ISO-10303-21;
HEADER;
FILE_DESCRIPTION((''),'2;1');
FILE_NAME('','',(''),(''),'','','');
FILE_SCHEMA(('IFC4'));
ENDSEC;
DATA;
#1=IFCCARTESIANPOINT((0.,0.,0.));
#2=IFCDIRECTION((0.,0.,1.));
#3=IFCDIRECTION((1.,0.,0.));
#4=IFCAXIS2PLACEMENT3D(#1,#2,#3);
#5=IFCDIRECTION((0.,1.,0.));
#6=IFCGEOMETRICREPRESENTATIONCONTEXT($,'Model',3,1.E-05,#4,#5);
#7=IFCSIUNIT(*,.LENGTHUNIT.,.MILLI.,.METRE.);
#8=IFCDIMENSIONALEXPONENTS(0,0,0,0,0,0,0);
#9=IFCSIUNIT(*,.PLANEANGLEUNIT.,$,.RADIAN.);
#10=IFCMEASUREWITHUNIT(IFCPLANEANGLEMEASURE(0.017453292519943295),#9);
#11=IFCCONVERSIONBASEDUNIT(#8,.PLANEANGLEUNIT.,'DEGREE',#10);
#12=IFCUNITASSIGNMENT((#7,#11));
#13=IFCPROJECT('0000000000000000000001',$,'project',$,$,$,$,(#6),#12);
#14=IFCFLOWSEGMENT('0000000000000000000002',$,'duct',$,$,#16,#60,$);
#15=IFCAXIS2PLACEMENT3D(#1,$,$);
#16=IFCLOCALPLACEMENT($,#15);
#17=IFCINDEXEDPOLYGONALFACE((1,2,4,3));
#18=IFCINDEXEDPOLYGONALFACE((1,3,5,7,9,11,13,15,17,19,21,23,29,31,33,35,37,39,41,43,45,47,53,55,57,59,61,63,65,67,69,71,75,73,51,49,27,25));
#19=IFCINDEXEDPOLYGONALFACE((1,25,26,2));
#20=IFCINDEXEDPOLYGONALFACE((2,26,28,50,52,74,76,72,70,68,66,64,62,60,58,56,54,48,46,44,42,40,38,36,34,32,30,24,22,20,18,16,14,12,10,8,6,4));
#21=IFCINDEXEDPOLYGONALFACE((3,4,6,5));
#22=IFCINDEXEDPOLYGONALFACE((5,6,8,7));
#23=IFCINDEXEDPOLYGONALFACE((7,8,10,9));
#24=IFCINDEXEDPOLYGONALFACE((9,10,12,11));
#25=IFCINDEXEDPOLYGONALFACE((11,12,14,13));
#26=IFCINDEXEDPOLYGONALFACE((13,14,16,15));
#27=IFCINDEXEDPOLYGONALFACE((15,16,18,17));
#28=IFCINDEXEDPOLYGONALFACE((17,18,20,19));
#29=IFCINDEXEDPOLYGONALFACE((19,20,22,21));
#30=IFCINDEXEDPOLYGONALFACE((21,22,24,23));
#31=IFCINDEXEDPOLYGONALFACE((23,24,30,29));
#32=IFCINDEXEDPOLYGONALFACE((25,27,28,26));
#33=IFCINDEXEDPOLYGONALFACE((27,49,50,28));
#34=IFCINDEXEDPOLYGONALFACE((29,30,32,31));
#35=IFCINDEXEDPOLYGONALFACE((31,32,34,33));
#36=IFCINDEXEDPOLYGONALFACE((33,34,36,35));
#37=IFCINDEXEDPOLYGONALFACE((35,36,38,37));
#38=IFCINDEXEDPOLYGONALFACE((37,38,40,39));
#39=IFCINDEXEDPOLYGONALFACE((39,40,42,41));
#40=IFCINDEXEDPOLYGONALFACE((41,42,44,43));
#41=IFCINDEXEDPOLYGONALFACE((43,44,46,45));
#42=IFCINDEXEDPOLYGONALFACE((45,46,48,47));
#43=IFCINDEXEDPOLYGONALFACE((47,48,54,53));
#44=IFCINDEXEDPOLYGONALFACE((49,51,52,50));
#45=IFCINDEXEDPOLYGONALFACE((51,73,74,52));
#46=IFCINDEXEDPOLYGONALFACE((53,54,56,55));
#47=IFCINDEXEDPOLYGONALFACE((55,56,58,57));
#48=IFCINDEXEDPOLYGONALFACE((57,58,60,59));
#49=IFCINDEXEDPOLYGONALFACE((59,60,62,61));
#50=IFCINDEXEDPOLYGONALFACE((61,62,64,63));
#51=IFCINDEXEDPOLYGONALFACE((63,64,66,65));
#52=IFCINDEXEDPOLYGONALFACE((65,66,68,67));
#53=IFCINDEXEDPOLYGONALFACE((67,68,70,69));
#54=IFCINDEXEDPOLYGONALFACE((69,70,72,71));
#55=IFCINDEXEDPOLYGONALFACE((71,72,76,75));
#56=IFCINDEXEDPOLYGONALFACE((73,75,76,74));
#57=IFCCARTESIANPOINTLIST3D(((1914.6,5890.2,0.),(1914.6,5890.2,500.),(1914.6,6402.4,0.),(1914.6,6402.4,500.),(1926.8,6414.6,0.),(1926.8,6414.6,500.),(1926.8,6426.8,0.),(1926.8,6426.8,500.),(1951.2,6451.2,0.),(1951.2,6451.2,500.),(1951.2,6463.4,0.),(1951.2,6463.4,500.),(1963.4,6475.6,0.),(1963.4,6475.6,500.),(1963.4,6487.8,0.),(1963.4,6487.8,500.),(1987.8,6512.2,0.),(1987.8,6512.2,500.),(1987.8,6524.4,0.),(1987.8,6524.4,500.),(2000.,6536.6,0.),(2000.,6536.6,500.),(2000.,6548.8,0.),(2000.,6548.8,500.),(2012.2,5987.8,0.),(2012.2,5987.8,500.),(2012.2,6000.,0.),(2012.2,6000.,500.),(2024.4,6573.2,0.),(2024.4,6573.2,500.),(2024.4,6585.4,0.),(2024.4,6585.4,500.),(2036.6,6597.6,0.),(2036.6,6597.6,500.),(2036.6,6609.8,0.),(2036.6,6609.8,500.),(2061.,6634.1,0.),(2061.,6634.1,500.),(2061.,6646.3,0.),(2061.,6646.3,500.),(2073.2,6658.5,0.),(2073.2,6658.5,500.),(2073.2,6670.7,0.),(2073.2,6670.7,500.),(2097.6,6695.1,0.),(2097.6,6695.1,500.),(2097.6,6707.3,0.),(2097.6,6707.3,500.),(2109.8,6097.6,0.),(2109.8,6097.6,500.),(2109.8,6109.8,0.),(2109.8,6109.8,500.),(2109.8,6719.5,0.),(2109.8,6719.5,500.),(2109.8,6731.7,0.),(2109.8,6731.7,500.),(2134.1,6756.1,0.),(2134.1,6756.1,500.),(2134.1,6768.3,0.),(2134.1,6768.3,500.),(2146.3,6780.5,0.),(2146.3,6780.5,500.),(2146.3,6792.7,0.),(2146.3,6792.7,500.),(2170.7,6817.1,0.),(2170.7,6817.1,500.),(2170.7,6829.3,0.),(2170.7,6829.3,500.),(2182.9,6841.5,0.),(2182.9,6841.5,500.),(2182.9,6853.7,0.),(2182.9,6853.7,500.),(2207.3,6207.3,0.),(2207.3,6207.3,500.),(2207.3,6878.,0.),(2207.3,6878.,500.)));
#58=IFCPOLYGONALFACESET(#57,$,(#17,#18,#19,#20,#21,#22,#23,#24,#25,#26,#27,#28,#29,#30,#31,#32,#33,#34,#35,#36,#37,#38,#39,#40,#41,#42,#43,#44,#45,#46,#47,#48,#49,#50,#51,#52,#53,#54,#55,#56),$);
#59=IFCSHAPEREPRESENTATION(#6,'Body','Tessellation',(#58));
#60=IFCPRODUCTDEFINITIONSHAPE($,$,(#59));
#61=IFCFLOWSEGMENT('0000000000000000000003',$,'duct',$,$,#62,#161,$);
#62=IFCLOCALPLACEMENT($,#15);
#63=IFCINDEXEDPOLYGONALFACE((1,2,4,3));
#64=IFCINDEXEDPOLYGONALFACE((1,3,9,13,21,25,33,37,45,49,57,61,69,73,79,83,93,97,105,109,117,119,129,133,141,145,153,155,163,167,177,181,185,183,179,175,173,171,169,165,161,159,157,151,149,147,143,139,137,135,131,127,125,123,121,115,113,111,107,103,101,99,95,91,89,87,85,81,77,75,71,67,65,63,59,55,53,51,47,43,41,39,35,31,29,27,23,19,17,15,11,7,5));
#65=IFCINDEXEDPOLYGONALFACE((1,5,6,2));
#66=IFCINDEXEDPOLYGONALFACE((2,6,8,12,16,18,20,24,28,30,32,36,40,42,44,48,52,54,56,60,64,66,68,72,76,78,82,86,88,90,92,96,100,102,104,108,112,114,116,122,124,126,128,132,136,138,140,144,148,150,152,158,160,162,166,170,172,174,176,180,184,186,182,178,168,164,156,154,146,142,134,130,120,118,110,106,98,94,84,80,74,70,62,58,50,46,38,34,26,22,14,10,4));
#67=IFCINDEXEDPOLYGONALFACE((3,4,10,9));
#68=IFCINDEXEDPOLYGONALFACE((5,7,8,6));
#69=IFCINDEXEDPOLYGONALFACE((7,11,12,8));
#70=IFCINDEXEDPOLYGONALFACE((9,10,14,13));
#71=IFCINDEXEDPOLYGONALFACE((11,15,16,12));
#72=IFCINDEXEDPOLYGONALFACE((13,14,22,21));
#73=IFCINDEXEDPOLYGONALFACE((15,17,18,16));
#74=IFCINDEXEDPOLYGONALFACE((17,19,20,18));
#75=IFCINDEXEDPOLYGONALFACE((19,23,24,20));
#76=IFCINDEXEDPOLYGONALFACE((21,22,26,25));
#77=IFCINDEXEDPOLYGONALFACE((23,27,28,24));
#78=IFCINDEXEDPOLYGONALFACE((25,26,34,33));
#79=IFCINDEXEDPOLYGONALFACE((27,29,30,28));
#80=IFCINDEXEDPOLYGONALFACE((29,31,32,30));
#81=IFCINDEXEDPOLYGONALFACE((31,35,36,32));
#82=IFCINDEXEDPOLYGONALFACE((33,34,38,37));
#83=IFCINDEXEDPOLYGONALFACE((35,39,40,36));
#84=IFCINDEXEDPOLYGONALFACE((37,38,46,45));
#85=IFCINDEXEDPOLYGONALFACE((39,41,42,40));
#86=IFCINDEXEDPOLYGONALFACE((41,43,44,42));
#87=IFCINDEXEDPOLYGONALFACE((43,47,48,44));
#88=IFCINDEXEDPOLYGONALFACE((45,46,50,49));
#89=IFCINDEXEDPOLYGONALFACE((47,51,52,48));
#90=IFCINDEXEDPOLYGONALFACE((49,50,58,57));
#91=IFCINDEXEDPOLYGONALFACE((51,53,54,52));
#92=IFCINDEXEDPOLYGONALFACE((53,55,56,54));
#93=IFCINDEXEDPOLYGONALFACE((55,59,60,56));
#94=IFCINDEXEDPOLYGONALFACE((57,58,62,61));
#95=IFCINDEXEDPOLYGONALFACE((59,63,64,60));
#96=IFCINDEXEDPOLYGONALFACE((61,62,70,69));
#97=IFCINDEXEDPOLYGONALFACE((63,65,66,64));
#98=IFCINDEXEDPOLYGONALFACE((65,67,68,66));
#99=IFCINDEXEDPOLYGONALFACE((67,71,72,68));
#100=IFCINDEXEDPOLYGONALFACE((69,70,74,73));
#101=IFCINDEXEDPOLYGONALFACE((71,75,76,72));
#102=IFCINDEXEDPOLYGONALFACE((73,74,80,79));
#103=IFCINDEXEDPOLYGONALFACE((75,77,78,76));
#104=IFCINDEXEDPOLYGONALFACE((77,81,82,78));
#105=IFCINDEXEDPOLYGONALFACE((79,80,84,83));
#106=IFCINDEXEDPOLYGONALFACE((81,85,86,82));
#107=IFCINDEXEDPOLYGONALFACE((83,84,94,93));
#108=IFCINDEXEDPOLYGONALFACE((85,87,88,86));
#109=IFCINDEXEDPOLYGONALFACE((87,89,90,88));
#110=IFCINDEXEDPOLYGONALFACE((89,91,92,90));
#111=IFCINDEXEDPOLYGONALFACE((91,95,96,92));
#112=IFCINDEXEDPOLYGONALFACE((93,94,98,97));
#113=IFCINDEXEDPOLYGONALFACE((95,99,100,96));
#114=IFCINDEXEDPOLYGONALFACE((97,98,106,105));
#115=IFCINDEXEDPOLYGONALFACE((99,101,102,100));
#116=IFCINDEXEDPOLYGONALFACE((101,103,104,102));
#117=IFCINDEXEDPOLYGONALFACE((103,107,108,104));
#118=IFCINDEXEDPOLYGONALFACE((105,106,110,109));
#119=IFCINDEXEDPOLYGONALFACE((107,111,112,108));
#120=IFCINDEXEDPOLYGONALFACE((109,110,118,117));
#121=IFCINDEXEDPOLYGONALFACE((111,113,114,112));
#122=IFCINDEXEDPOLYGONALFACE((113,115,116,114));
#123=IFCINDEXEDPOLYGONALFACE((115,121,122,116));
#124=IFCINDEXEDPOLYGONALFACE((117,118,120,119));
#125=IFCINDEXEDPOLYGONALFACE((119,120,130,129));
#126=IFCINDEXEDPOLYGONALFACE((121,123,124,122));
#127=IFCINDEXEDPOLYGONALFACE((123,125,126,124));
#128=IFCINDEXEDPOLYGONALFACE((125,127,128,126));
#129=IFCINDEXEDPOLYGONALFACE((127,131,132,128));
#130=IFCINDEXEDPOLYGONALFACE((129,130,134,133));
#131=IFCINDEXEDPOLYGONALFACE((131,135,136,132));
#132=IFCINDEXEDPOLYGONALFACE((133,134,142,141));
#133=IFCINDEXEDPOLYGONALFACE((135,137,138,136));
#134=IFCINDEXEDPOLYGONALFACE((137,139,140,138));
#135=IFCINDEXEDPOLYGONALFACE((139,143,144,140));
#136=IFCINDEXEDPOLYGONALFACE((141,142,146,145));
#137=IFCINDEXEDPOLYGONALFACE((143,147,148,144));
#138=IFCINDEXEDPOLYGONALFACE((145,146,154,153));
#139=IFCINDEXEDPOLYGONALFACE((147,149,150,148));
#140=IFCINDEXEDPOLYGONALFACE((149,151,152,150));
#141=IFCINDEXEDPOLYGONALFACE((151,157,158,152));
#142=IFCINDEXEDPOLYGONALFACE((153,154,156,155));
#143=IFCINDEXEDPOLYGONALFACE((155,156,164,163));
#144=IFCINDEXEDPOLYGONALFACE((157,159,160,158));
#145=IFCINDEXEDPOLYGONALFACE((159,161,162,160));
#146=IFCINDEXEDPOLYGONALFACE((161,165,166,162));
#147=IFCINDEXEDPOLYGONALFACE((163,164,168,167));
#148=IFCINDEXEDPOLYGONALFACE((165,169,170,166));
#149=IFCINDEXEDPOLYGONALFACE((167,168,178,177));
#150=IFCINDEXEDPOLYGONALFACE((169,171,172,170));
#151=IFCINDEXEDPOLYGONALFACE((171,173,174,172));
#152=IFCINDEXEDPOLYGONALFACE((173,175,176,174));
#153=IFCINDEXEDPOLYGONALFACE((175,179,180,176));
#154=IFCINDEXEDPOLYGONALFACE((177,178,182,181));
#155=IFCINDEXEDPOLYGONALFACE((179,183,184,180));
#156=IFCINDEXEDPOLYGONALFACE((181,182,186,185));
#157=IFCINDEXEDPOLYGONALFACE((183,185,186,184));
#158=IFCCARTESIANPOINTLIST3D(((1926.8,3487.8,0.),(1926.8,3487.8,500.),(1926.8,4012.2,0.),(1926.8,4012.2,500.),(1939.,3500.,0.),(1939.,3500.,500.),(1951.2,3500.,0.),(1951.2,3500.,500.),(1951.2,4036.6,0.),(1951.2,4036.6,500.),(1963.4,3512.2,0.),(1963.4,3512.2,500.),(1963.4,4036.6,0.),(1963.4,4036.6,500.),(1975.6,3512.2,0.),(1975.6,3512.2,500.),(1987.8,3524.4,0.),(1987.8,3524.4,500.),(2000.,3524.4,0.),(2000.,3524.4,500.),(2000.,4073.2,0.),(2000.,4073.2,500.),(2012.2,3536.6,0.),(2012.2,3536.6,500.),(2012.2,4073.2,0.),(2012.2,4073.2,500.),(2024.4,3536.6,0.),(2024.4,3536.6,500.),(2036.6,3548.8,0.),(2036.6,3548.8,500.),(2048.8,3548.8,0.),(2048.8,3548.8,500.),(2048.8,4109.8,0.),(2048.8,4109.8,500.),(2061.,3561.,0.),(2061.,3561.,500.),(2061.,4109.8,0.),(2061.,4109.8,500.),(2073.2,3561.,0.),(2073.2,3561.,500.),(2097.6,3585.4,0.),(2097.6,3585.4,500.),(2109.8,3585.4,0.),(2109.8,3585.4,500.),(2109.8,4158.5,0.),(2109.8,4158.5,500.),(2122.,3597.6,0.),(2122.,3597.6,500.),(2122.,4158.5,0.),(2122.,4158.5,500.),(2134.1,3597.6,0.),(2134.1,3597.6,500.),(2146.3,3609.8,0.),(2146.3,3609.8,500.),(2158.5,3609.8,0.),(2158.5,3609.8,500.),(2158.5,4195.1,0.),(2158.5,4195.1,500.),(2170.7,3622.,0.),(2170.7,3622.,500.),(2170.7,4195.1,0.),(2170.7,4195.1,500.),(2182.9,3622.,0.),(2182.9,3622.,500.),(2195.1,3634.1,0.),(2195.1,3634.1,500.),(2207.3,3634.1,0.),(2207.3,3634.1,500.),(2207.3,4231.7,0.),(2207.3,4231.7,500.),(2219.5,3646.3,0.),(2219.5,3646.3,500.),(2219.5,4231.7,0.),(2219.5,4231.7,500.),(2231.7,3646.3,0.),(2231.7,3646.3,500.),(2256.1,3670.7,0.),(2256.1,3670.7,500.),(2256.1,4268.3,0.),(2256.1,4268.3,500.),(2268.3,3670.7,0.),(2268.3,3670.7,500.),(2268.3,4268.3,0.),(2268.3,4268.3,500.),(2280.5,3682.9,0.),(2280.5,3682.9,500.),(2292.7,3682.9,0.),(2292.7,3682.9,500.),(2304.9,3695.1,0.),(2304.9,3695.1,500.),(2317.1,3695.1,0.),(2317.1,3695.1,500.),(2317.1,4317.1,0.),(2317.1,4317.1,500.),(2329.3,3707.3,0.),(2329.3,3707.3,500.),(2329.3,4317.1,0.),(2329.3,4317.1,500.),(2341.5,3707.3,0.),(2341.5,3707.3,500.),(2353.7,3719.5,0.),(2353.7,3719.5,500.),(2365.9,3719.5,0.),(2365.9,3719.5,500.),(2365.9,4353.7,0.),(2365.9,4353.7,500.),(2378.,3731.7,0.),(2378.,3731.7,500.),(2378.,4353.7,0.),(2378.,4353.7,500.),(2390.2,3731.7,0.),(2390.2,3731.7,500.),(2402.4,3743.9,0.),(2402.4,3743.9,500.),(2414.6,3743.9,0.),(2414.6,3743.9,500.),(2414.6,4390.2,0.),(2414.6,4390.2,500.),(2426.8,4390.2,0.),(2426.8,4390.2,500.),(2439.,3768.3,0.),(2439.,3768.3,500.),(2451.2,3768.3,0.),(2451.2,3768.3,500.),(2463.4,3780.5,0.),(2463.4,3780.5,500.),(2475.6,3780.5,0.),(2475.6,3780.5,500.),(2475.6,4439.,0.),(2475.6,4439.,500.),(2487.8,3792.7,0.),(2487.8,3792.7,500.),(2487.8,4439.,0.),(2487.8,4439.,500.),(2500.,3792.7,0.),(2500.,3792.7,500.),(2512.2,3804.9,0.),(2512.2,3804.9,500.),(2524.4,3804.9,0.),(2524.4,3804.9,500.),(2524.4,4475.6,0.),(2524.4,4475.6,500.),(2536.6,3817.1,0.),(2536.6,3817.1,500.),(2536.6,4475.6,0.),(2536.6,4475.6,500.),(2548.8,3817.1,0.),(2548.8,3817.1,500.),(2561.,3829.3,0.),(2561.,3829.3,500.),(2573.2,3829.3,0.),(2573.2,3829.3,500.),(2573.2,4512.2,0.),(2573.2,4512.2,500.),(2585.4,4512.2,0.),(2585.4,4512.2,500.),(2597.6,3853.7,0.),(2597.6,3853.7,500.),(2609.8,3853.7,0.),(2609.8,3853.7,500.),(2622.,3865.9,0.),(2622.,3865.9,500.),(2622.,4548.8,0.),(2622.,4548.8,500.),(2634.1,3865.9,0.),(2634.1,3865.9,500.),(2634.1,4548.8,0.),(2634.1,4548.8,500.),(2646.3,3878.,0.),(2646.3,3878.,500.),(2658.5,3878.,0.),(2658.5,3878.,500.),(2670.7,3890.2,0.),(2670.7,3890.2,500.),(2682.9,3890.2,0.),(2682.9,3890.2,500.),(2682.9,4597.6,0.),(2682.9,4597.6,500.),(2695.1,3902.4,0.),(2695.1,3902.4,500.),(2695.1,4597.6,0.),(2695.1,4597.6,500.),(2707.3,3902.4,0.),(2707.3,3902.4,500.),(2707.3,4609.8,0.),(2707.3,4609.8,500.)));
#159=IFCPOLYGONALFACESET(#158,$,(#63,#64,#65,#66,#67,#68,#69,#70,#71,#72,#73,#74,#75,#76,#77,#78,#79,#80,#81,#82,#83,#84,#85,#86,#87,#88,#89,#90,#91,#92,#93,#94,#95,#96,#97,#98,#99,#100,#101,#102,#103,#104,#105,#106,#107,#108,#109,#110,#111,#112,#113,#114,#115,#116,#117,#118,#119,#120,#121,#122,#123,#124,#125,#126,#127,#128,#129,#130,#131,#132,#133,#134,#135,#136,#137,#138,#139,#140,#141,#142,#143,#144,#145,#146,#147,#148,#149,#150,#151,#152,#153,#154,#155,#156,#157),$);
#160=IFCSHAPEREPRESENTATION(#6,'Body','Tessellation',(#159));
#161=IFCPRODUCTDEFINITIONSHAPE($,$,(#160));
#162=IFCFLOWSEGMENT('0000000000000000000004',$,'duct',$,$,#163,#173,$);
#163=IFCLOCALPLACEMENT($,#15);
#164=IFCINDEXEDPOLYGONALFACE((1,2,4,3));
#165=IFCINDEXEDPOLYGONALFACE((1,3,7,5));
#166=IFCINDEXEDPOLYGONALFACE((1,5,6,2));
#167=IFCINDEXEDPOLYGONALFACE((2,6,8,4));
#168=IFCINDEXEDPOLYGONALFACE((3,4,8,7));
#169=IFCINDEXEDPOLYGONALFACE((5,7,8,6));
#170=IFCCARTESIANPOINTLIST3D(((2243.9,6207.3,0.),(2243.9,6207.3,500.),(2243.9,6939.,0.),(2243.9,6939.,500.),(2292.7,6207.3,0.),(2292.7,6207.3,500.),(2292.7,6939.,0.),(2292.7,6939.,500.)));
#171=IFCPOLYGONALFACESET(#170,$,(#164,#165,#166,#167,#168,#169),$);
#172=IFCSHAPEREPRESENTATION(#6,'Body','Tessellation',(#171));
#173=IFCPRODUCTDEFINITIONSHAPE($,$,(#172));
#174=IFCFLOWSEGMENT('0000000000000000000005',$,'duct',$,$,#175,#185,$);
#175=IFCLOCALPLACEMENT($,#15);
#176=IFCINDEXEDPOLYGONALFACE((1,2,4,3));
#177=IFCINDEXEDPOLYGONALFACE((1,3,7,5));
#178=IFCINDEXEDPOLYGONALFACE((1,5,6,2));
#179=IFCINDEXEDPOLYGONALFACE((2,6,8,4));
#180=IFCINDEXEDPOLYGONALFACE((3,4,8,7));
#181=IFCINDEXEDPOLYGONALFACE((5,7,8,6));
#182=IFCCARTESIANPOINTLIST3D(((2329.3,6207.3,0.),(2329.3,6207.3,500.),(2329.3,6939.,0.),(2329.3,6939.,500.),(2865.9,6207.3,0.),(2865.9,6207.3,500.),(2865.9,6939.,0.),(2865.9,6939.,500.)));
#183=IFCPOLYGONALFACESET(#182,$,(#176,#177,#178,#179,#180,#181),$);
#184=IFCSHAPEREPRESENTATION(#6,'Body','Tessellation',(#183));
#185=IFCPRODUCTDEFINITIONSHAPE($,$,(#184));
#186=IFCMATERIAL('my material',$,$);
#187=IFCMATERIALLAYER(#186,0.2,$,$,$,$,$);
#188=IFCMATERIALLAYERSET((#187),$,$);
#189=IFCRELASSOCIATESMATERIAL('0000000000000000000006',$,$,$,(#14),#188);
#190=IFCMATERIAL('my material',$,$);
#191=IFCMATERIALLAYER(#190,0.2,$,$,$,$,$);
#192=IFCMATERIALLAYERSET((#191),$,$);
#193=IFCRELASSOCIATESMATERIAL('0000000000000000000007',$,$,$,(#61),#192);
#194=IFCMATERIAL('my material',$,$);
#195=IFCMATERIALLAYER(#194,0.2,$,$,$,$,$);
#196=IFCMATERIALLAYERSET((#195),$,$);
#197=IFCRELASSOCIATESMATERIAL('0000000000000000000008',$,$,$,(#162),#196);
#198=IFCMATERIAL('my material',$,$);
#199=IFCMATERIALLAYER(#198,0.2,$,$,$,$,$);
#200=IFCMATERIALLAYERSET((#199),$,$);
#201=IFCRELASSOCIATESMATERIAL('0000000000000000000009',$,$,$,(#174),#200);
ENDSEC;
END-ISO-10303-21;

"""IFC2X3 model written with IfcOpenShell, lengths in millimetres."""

from ifc_helpers import new_model, entity, si_unit, converted_unit, direction, origin_with_axes, place, context, project, polyline, outline, extrude, material, layer, layer_set, layer_usage, element, save


model = new_model("IFC2X3")

# Units and contexts
model_context = context("Model", 3, precision=1e-05, world=origin_with_axes(), true_north=direction((0.0, 1.0, 0.0)))
ifc_project = project(units=[si_unit("LENGTHUNIT", "METRE", prefix="MILLI"), converted_unit("PLANEANGLEUNIT", "DEGREE", entity("IfcPlaneAngleMeasure", 0.017453292519943295), si_unit("PLANEANGLEUNIT", "RADIAN"), dimensions=[0, 0, 0, 0, 0, 0, 0])], contexts=[model_context])

# Flow segments
ifc_material_1 = material(Name="my material")
ifc_layer_1 = layer(ifc_material_1, 0.2)
ifc_layer_set_1 = layer_set([ifc_layer_1])
ifc_layer_usage_1 = layer_usage(ifc_layer_set_1, "AXIS2", "POSITIVE", -0.1)
flow_segment_1_placement = place(None, origin_with_axes())
element("IfcFlowSegment", 1, at=flow_segment_1_placement, material=ifc_layer_usage_1, Name="duct", context=model_context, shape_type="SweptSolid", body=[
    extrude(outline(polyline([(1914.6, 5878.0), (1914.6, 5890.2), (2012.2, 5987.8), (2012.2, 6000.0), (2109.8, 6097.6), (2109.8, 6109.8), (2207.3, 6207.3), (2207.3, 6890.2), (2207.3, 6878.0), (2182.9, 6853.7), (2182.9, 6841.5), (2170.7, 6829.3), (2170.7, 6817.1), (2146.3, 6792.7), (2146.3, 6780.5), (2134.1, 6768.3), (2134.1, 6756.1), (2109.8, 6731.7), (2109.8, 6719.5), (2097.6, 6707.3), (2097.6, 6695.1), (2073.2, 6670.7), (2073.2, 6658.5), (2061.0, 6646.3), (2061.0, 6634.1), (2036.6, 6609.8), (2036.6, 6597.6), (2024.4, 6585.4), (2024.4, 6573.2), (2000.0, 6548.8), (2000.0, 6536.6), (1987.8, 6524.4), (1987.8, 6512.2), (1963.4, 6487.8), (1963.4, 6475.6), (1951.2, 6463.4), (1951.2, 6451.2), (1926.8, 6426.8), (1926.8, 6414.6), (1914.6, 6402.4), (1914.6, 5878.0)])), origin_with_axes(), (0.0, 0.0, 1.0), 500.0),
])
ifc_material_2 = material(Name="my material")
ifc_layer_2 = layer(ifc_material_2, 0.2)
ifc_layer_set_2 = layer_set([ifc_layer_2])
ifc_layer_usage_2 = layer_usage(ifc_layer_set_2, "AXIS2", "POSITIVE", -0.1)
flow_segment_2_placement = place(None, origin_with_axes())
element("IfcFlowSegment", 2, at=flow_segment_2_placement, material=ifc_layer_usage_2, Name="duct", context=model_context, shape_type="SweptSolid", body=[
    extrude(outline(polyline([(1926.8, 3487.8), (1939.0, 3500.0), (1951.2, 3500.0), (1963.4, 3512.2), (1975.6, 3512.2), (1987.8, 3524.4), (2000.0, 3524.4), (2012.2, 3536.6), (2024.4, 3536.6), (2036.6, 3548.8), (2048.8, 3548.8), (2061.0, 3561.0), (2073.2, 3561.0), (2097.6, 3585.4), (2109.8, 3585.4), (2122.0, 3597.6), (2134.1, 3597.6), (2146.3, 3609.8), (2158.5, 3609.8), (2170.7, 3622.0), (2182.9, 3622.0), (2195.1, 3634.1), (2207.3, 3634.1), (2219.5, 3646.3), (2231.7, 3646.3), (2256.1, 3670.7), (2268.3, 3670.7), (2280.5, 3682.9), (2292.7, 3682.9), (2304.9, 3695.1), (2317.1, 3695.1), (2329.3, 3707.3), (2341.5, 3707.3), (2353.7, 3719.5), (2365.9, 3719.5), (2378.0, 3731.7), (2390.2, 3731.7), (2402.4, 3743.9), (2414.6, 3743.9), (2439.0, 3768.3), (2451.2, 3768.3), (2463.4, 3780.5), (2475.6, 3780.5), (2487.8, 3792.7), (2500.0, 3792.7), (2512.2, 3804.9), (2524.4, 3804.9), (2536.6, 3817.1), (2548.8, 3817.1), (2561.0, 3829.3), (2573.2, 3829.3), (2597.6, 3853.7), (2609.8, 3853.7), (2622.0, 3865.9), (2634.1, 3865.9), (2646.3, 3878.0), (2658.5, 3878.0), (2670.7, 3890.2), (2682.9, 3890.2), (2695.1, 3902.4), (2707.3, 3902.4), (2707.3, 4609.8), (2695.1, 4597.6), (2682.9, 4597.6), (2634.1, 4548.8), (2622.0, 4548.8), (2585.4, 4512.2), (2573.2, 4512.2), (2536.6, 4475.6), (2524.4, 4475.6), (2487.8, 4439.0), (2475.6, 4439.0), (2426.8, 4390.2), (2414.6, 4390.2), (2378.0, 4353.7), (2365.9, 4353.7), (2329.3, 4317.1), (2317.1, 4317.1), (2268.3, 4268.3), (2256.1, 4268.3), (2219.5, 4231.7), (2207.3, 4231.7), (2170.7, 4195.1), (2158.5, 4195.1), (2122.0, 4158.5), (2109.8, 4158.5), (2061.0, 4109.8), (2048.8, 4109.8), (2012.2, 4073.2), (2000.0, 4073.2), (1963.4, 4036.6), (1951.2, 4036.6), (1926.8, 4012.2), (1926.8, 3487.8)])), origin_with_axes(), (0.0, 0.0, 1.0), 500.0),
])
ifc_material_3 = material(Name="my material")
ifc_layer_3 = layer(ifc_material_3, 0.2)
ifc_layer_set_3 = layer_set([ifc_layer_3])
ifc_layer_usage_3 = layer_usage(ifc_layer_set_3, "AXIS2", "POSITIVE", -0.1)
flow_segment_3_placement = place(None, origin_with_axes())
element("IfcFlowSegment", 3, at=flow_segment_3_placement, material=ifc_layer_usage_3, Name="duct", context=model_context, shape_type="SweptSolid", body=[
    extrude(outline(polyline([(2243.9, 6207.3), (2292.7, 6207.3), (2292.7, 6939.0), (2243.9, 6939.0), (2243.9, 6207.3)])), origin_with_axes(), (0.0, 0.0, 1.0), 500.0),
])
ifc_material_4 = material(Name="my material")
ifc_layer_4 = layer(ifc_material_4, 0.2)
ifc_layer_set_4 = layer_set([ifc_layer_4])
ifc_layer_usage_4 = layer_usage(ifc_layer_set_4, "AXIS2", "POSITIVE", -0.1)
flow_segment_4_placement = place(None, origin_with_axes())
element("IfcFlowSegment", 4, at=flow_segment_4_placement, material=ifc_layer_usage_4, Name="duct", context=model_context, shape_type="SweptSolid", body=[
    extrude(outline(polyline([(2329.3, 6207.3), (2865.9, 6207.3), (2865.9, 6939.0), (2329.3, 6939.0), (2329.3, 6207.3)])), origin_with_axes(), (0.0, 0.0, 1.0), 500.0),
])

save(model, "model.ifc")
